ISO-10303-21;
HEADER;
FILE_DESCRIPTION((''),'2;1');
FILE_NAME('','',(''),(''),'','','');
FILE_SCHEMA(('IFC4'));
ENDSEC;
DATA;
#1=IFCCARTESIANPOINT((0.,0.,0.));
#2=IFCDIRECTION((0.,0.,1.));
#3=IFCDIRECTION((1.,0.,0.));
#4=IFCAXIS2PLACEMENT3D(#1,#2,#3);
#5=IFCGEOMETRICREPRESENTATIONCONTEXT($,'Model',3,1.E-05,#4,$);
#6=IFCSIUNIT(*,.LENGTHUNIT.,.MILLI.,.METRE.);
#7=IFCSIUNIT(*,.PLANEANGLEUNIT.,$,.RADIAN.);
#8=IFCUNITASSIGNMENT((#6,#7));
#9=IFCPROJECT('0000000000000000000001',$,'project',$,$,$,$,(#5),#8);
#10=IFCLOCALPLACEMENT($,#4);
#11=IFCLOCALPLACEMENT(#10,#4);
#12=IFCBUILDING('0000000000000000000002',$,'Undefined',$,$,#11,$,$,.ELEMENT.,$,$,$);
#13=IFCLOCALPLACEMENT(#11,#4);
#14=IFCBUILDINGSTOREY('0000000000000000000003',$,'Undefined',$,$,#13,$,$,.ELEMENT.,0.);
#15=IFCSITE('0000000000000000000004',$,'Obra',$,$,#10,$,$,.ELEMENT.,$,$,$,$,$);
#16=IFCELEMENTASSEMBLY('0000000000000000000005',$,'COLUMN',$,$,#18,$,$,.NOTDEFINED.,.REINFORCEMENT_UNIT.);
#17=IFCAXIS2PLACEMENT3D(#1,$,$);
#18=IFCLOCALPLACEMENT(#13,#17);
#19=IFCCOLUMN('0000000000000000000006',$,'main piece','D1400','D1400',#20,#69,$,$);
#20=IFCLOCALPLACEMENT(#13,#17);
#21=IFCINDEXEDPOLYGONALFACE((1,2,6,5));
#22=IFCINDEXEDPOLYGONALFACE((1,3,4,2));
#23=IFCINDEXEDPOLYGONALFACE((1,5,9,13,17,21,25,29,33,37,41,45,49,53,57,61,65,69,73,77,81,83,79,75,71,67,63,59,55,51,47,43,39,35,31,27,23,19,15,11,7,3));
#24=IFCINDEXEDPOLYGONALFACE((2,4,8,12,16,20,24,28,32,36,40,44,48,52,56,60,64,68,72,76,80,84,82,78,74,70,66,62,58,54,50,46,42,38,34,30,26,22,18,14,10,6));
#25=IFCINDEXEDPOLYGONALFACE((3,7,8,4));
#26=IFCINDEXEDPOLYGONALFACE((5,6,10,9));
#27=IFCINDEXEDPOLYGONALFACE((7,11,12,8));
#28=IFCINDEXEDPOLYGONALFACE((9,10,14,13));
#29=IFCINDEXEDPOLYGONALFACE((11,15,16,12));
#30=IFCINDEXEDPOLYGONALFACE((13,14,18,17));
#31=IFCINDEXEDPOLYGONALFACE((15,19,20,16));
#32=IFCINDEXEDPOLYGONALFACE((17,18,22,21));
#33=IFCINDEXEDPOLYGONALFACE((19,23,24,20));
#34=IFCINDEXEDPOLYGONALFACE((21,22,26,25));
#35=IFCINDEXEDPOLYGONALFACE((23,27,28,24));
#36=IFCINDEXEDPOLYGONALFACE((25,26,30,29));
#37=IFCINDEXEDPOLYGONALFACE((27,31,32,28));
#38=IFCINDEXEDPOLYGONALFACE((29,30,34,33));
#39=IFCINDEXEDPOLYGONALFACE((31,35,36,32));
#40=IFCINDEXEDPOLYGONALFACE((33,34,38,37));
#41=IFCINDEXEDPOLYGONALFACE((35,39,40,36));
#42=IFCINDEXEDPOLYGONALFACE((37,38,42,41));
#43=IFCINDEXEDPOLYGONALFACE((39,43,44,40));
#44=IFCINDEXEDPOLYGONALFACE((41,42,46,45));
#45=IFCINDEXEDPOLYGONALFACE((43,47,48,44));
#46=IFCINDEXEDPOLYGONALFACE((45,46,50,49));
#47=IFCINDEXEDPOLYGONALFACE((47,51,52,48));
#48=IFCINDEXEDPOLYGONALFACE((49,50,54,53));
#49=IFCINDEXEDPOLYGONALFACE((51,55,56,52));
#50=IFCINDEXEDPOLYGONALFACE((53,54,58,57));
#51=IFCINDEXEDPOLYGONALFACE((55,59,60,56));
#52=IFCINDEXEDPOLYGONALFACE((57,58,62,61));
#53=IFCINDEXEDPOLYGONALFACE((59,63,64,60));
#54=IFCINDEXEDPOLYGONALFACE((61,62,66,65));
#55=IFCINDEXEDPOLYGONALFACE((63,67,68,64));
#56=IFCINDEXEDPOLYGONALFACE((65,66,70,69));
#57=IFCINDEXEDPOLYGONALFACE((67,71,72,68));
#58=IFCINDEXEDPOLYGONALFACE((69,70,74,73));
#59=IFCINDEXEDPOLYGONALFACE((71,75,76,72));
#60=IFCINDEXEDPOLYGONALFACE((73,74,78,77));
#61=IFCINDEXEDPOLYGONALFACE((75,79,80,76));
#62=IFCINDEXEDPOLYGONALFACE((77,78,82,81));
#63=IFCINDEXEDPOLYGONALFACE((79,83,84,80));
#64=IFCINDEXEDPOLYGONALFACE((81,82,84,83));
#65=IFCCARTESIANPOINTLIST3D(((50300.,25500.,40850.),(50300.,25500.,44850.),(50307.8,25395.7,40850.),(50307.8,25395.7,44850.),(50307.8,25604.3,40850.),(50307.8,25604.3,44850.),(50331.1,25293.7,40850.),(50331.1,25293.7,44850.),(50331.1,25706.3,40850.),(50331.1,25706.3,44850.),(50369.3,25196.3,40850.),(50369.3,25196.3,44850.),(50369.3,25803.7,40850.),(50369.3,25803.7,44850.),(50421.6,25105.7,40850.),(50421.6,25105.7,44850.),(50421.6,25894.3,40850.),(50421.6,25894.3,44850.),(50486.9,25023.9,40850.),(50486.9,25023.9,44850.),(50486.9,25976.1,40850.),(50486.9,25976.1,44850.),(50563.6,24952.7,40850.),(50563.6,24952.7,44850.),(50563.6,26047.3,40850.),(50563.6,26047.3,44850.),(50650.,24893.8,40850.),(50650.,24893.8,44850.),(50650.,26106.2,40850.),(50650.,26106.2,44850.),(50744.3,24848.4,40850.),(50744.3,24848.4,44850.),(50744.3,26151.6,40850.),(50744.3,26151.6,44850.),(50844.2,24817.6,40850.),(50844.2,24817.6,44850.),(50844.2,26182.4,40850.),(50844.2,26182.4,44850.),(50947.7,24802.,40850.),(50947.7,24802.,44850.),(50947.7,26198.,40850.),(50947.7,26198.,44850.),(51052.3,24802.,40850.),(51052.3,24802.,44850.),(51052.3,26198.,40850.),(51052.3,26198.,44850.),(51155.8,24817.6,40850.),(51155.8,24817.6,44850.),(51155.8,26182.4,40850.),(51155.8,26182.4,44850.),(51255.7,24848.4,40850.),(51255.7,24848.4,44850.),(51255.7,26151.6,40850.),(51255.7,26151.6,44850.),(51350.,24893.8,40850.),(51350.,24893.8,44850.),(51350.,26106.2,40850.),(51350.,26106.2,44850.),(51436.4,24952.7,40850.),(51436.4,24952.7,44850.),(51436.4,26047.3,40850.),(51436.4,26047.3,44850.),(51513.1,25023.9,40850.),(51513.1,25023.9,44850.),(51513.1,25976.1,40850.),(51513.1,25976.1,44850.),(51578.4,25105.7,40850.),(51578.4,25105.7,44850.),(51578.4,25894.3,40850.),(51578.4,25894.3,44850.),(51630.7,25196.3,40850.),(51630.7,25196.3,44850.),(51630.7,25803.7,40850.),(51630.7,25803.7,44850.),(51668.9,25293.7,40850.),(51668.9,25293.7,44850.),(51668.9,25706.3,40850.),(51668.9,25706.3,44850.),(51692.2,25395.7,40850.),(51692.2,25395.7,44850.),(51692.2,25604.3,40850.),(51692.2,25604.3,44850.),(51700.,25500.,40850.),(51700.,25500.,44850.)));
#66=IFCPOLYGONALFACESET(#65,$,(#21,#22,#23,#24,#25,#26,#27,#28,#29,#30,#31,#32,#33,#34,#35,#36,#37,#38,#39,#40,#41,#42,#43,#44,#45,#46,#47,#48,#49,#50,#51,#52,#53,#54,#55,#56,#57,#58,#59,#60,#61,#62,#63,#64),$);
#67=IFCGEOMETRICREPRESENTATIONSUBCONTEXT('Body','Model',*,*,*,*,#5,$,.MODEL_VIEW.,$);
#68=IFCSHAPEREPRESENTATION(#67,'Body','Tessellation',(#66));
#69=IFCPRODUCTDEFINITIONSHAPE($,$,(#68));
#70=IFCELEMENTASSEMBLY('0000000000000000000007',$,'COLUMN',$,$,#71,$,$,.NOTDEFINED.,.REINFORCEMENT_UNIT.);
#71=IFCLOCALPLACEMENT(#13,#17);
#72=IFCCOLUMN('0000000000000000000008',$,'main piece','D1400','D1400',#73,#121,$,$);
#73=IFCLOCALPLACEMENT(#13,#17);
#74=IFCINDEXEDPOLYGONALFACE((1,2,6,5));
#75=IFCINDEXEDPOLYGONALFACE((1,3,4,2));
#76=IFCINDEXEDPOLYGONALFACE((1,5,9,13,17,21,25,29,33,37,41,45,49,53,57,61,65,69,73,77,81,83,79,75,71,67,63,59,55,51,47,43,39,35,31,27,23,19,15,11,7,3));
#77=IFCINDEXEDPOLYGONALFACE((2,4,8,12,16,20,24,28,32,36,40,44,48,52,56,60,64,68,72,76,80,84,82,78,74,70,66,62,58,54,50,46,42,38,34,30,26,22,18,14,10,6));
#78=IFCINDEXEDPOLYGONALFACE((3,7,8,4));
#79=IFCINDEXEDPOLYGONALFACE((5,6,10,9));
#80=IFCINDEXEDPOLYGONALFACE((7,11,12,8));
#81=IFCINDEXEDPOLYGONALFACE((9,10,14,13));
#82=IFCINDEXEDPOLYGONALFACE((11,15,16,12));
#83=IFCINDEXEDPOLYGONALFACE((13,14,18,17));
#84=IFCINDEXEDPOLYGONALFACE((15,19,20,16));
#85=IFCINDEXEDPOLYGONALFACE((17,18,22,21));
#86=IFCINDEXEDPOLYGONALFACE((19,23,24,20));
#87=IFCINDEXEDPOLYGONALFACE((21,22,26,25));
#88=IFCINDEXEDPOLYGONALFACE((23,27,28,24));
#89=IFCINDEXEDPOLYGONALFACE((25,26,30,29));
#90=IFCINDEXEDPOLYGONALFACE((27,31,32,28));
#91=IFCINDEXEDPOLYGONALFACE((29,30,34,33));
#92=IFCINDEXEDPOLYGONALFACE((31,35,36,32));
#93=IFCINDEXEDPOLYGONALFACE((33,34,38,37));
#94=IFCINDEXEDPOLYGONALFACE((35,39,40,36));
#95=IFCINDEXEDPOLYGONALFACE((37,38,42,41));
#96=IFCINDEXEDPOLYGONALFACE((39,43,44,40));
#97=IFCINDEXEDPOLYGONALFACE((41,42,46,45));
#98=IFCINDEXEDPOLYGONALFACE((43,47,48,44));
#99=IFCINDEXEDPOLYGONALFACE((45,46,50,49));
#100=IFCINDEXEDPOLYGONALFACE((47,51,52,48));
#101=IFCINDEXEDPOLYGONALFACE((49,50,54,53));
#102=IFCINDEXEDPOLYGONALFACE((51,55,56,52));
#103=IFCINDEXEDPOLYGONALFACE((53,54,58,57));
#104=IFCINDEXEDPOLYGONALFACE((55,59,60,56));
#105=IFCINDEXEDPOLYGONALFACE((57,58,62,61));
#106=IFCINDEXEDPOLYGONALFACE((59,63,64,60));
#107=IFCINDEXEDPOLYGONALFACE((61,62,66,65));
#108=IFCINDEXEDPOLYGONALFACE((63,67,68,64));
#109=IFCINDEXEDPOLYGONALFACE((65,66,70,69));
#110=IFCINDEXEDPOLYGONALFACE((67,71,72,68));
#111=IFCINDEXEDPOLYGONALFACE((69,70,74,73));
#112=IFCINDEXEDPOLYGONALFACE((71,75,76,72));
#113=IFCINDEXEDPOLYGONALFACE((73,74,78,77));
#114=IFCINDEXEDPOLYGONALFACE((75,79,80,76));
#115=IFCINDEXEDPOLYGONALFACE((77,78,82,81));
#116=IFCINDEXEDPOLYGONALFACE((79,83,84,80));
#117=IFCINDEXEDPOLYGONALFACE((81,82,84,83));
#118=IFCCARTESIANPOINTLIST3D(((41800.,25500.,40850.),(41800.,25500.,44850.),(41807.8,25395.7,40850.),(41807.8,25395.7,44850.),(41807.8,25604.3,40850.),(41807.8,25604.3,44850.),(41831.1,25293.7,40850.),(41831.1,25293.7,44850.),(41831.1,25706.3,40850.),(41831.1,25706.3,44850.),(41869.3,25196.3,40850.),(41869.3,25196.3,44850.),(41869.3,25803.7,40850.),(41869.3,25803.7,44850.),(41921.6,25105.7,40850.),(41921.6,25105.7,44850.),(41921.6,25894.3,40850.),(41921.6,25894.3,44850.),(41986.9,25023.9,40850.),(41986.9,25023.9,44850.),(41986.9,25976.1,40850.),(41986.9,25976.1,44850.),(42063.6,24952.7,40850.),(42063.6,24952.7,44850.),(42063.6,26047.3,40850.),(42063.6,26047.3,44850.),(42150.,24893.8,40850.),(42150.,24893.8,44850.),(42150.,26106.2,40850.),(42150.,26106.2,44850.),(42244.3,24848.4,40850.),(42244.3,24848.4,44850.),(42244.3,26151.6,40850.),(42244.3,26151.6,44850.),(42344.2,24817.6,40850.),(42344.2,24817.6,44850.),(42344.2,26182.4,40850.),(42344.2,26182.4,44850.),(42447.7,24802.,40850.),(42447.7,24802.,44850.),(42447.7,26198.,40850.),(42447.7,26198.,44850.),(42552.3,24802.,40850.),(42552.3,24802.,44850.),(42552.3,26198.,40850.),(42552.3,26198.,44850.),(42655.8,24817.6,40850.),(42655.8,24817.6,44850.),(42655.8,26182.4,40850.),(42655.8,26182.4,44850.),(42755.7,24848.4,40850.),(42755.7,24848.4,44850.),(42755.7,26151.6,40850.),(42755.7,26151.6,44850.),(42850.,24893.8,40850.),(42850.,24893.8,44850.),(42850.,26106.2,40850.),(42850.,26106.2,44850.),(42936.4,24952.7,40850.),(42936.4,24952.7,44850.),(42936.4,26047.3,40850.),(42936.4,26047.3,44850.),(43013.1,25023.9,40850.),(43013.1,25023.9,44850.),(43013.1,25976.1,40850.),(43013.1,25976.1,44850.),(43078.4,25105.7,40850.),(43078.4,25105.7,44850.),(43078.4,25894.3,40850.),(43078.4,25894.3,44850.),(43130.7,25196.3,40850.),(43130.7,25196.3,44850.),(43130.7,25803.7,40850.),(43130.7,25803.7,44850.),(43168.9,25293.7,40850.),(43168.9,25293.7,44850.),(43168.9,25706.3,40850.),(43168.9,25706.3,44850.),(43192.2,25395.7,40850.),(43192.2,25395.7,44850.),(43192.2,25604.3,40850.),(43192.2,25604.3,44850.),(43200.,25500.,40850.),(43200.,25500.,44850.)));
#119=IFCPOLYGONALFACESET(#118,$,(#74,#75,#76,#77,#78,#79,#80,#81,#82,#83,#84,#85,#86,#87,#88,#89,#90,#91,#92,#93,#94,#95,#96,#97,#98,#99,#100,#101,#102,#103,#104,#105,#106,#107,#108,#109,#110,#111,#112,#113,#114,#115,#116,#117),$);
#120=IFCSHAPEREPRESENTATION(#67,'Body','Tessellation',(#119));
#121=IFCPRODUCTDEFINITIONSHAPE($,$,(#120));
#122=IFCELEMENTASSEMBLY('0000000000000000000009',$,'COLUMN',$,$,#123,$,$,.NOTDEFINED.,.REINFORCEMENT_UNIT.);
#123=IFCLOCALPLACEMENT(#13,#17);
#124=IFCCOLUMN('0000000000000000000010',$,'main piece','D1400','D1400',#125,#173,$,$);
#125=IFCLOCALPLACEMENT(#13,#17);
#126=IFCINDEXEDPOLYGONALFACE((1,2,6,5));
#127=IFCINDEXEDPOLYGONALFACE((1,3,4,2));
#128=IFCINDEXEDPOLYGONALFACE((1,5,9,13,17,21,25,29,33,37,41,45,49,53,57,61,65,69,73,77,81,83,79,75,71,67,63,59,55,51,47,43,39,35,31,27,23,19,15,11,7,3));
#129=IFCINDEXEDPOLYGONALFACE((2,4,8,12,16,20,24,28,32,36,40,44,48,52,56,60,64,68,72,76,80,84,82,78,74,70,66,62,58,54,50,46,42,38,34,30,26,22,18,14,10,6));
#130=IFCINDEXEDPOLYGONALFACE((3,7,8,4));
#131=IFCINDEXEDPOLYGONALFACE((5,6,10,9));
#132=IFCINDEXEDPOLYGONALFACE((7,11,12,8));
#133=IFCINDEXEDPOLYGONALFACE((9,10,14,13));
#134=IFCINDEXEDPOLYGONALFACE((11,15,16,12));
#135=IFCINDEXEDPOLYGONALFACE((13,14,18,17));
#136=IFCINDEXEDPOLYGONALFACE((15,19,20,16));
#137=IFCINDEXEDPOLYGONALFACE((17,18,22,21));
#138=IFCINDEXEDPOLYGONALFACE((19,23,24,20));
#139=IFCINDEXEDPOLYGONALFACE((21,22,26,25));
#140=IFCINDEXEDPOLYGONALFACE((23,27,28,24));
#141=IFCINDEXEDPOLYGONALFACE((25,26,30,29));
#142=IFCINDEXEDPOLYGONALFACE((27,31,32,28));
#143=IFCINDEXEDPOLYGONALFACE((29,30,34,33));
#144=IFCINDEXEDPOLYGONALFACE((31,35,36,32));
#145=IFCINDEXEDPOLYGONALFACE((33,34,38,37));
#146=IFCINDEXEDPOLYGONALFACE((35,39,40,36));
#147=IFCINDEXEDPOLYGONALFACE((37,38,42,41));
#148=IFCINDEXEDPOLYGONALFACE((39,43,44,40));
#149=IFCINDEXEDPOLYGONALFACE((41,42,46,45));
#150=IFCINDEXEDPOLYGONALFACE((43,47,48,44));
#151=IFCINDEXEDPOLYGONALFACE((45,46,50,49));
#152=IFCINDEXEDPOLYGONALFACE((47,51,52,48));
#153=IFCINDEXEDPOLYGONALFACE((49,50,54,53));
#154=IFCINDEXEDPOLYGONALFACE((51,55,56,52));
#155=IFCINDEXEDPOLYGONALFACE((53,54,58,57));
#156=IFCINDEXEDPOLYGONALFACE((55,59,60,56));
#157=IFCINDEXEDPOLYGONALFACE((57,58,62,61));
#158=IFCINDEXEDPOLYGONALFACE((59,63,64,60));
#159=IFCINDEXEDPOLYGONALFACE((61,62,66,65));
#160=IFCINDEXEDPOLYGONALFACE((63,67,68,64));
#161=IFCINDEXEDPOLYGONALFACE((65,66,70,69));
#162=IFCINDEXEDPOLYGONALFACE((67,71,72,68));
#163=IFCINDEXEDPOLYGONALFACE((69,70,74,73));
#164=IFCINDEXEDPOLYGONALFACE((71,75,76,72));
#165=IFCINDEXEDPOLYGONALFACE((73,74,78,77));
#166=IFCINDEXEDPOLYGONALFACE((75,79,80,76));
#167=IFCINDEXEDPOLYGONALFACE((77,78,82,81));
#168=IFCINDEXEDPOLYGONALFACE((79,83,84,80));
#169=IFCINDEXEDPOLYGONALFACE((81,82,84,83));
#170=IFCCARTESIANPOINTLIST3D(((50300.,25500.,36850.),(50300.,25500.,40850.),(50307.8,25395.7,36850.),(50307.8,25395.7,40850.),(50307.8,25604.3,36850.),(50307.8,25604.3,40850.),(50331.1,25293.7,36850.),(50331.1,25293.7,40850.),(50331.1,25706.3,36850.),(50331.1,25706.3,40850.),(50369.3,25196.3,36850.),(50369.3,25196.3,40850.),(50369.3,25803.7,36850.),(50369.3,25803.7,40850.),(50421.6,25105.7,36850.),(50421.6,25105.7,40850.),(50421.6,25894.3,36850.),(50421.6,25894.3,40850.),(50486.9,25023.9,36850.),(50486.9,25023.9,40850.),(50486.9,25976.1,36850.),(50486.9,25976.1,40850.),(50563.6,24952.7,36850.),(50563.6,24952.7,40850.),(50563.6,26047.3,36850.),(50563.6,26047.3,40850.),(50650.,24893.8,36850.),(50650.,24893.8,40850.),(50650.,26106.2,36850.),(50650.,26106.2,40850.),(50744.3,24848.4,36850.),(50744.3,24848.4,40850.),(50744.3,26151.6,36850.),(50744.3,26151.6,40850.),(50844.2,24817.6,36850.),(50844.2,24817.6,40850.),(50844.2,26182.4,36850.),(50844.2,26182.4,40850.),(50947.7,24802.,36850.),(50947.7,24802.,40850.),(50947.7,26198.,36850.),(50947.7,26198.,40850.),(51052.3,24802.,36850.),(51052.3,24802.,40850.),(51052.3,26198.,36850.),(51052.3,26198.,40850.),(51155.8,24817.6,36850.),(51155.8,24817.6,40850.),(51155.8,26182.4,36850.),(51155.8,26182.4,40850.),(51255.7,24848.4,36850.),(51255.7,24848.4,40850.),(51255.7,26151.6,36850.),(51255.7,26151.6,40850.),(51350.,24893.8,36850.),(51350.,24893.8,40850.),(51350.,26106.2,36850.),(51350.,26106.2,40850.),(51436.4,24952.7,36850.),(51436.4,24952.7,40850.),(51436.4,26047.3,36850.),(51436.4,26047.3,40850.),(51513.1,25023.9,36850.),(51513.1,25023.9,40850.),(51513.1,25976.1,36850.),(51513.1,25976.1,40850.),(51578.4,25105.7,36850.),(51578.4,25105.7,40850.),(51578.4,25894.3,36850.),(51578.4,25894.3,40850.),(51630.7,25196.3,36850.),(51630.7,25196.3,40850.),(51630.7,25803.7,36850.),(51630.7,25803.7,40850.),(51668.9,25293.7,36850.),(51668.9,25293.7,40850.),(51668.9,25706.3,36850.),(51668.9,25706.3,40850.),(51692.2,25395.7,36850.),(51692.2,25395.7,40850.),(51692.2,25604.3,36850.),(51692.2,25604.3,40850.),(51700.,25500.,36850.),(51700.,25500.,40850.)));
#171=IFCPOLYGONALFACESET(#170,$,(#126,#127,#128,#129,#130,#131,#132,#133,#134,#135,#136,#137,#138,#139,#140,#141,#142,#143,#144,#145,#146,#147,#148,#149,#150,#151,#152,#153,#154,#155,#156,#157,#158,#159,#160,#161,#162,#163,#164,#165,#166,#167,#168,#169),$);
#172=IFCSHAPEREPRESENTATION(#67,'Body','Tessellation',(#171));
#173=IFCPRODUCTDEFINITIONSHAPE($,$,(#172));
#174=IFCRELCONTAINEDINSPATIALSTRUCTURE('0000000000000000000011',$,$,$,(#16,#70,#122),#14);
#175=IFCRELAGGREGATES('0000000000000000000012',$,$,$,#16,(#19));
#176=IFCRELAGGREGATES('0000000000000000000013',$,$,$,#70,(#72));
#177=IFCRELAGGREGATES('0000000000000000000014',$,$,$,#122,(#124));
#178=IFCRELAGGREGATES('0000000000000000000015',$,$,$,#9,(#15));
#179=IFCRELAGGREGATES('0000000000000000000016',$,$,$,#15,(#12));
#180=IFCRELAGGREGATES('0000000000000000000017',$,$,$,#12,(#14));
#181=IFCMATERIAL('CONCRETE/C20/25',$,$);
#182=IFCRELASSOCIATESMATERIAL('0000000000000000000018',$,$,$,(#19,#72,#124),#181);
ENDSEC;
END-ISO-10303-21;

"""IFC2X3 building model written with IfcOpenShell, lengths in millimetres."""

from ifc_helpers import new_model, si_unit, frame, origin_with_axes, origin_2d_with_axis, place, context, subcontext, project, spatial, circle, extrude, material, element, aggregate, save


model = new_model("IFC2X3")

# Units and contexts
model_context = context("Model", 3, precision=1e-05, world=origin_with_axes())
body_context = subcontext(model_context, "Body", "Model", "MODEL_VIEW")
ifc_project = project(units=[si_unit("LENGTHUNIT", "METRE", prefix="MILLI"), si_unit("PLANEANGLEUNIT", "RADIAN")], contexts=[model_context])

# Site, building, storey
site_placement = place(None, origin_with_axes())
site = spatial("IfcSite", under=ifc_project, at=site_placement, Name="Obra", CompositionType="ELEMENT")
building_placement = place(site_placement, origin_with_axes())
building = spatial("IfcBuilding", under=site, at=building_placement, Name="Undefined", CompositionType="ELEMENT")
storey_placement = place(building_placement, origin_with_axes())
storey = spatial("IfcBuildingStorey", under=building, at=storey_placement, Name="Undefined", CompositionType="ELEMENT", Elevation=0.0)

# Element assemblies, columns
assembly_1_placement = place(storey_placement, origin_with_axes())
assembly_1 = element("IfcElementAssembly", 1, at=assembly_1_placement, inside=storey, Name="COLUMN", AssemblyPlace="NOTDEFINED", PredefinedType="REINFORCEMENT_UNIT")
ifc_material_1 = material(Name="CONCRETE/C20/25")
column_1_placement = place(assembly_1_placement, frame((51000.0, 25500.0, 40850.0), z_axis=(0.0, 0.0, 1.0), x_axis=(0.0, 1.0, 0.0)))
column_1 = element("IfcColumn", 2, at=column_1_placement, material=ifc_material_1, Name="main piece", Description="D1400", ObjectType="D1400", context=body_context, shape_type="SweptSolid", body=[
    extrude(circle(Radius=700.0, at=origin_2d_with_axis()), frame((0.0, 0.0, 4000.0), z_axis=(0.0, 0.0, -1.0), x_axis=(0.0, 1.0, 0.0)), (0.0, 0.0, 1.0), 4000.0),
])
aggregate(assembly_1, [column_1])
assembly_2_placement = place(storey_placement, origin_with_axes())
assembly_2 = element("IfcElementAssembly", 3, at=assembly_2_placement, inside=storey, Name="COLUMN", AssemblyPlace="NOTDEFINED", PredefinedType="REINFORCEMENT_UNIT")
column_2_placement = place(assembly_2_placement, frame((42500.0, 25500.0, 40850.0), z_axis=(0.0, 0.0, 1.0), x_axis=(0.0, 1.0, 0.0)))
column_2 = element("IfcColumn", 4, at=column_2_placement, material=ifc_material_1, Name="main piece", Description="D1400", ObjectType="D1400", context=body_context, shape_type="SweptSolid", body=[
    extrude(circle(Radius=700.0, at=origin_2d_with_axis()), frame((0.0, 0.0, 4000.0), z_axis=(0.0, 0.0, -1.0), x_axis=(0.0, 1.0, 0.0)), (0.0, 0.0, 1.0), 4000.0),
])
aggregate(assembly_2, [column_2])
assembly_3_placement = place(storey_placement, origin_with_axes())
assembly_3 = element("IfcElementAssembly", 5, at=assembly_3_placement, inside=storey, Name="COLUMN", AssemblyPlace="NOTDEFINED", PredefinedType="REINFORCEMENT_UNIT")
column_3_placement = place(assembly_3_placement, frame((51000.0, 25500.0, 36850.0), z_axis=(0.0, 0.0, 1.0), x_axis=(0.0, 1.0, 0.0)))
column_3 = element("IfcColumn", 6, at=column_3_placement, material=ifc_material_1, Name="main piece", Description="D1400", ObjectType="D1400", context=body_context, shape_type="SweptSolid", body=[
    extrude(circle(Radius=700.0, at=origin_2d_with_axis()), frame((0.0, 0.0, 4000.0), z_axis=(0.0, 0.0, -1.0), x_axis=(0.0, 1.0, 0.0)), (0.0, 0.0, 1.0), 4000.0),
])
aggregate(assembly_3, [column_3])

save(model, "model.ifc")
